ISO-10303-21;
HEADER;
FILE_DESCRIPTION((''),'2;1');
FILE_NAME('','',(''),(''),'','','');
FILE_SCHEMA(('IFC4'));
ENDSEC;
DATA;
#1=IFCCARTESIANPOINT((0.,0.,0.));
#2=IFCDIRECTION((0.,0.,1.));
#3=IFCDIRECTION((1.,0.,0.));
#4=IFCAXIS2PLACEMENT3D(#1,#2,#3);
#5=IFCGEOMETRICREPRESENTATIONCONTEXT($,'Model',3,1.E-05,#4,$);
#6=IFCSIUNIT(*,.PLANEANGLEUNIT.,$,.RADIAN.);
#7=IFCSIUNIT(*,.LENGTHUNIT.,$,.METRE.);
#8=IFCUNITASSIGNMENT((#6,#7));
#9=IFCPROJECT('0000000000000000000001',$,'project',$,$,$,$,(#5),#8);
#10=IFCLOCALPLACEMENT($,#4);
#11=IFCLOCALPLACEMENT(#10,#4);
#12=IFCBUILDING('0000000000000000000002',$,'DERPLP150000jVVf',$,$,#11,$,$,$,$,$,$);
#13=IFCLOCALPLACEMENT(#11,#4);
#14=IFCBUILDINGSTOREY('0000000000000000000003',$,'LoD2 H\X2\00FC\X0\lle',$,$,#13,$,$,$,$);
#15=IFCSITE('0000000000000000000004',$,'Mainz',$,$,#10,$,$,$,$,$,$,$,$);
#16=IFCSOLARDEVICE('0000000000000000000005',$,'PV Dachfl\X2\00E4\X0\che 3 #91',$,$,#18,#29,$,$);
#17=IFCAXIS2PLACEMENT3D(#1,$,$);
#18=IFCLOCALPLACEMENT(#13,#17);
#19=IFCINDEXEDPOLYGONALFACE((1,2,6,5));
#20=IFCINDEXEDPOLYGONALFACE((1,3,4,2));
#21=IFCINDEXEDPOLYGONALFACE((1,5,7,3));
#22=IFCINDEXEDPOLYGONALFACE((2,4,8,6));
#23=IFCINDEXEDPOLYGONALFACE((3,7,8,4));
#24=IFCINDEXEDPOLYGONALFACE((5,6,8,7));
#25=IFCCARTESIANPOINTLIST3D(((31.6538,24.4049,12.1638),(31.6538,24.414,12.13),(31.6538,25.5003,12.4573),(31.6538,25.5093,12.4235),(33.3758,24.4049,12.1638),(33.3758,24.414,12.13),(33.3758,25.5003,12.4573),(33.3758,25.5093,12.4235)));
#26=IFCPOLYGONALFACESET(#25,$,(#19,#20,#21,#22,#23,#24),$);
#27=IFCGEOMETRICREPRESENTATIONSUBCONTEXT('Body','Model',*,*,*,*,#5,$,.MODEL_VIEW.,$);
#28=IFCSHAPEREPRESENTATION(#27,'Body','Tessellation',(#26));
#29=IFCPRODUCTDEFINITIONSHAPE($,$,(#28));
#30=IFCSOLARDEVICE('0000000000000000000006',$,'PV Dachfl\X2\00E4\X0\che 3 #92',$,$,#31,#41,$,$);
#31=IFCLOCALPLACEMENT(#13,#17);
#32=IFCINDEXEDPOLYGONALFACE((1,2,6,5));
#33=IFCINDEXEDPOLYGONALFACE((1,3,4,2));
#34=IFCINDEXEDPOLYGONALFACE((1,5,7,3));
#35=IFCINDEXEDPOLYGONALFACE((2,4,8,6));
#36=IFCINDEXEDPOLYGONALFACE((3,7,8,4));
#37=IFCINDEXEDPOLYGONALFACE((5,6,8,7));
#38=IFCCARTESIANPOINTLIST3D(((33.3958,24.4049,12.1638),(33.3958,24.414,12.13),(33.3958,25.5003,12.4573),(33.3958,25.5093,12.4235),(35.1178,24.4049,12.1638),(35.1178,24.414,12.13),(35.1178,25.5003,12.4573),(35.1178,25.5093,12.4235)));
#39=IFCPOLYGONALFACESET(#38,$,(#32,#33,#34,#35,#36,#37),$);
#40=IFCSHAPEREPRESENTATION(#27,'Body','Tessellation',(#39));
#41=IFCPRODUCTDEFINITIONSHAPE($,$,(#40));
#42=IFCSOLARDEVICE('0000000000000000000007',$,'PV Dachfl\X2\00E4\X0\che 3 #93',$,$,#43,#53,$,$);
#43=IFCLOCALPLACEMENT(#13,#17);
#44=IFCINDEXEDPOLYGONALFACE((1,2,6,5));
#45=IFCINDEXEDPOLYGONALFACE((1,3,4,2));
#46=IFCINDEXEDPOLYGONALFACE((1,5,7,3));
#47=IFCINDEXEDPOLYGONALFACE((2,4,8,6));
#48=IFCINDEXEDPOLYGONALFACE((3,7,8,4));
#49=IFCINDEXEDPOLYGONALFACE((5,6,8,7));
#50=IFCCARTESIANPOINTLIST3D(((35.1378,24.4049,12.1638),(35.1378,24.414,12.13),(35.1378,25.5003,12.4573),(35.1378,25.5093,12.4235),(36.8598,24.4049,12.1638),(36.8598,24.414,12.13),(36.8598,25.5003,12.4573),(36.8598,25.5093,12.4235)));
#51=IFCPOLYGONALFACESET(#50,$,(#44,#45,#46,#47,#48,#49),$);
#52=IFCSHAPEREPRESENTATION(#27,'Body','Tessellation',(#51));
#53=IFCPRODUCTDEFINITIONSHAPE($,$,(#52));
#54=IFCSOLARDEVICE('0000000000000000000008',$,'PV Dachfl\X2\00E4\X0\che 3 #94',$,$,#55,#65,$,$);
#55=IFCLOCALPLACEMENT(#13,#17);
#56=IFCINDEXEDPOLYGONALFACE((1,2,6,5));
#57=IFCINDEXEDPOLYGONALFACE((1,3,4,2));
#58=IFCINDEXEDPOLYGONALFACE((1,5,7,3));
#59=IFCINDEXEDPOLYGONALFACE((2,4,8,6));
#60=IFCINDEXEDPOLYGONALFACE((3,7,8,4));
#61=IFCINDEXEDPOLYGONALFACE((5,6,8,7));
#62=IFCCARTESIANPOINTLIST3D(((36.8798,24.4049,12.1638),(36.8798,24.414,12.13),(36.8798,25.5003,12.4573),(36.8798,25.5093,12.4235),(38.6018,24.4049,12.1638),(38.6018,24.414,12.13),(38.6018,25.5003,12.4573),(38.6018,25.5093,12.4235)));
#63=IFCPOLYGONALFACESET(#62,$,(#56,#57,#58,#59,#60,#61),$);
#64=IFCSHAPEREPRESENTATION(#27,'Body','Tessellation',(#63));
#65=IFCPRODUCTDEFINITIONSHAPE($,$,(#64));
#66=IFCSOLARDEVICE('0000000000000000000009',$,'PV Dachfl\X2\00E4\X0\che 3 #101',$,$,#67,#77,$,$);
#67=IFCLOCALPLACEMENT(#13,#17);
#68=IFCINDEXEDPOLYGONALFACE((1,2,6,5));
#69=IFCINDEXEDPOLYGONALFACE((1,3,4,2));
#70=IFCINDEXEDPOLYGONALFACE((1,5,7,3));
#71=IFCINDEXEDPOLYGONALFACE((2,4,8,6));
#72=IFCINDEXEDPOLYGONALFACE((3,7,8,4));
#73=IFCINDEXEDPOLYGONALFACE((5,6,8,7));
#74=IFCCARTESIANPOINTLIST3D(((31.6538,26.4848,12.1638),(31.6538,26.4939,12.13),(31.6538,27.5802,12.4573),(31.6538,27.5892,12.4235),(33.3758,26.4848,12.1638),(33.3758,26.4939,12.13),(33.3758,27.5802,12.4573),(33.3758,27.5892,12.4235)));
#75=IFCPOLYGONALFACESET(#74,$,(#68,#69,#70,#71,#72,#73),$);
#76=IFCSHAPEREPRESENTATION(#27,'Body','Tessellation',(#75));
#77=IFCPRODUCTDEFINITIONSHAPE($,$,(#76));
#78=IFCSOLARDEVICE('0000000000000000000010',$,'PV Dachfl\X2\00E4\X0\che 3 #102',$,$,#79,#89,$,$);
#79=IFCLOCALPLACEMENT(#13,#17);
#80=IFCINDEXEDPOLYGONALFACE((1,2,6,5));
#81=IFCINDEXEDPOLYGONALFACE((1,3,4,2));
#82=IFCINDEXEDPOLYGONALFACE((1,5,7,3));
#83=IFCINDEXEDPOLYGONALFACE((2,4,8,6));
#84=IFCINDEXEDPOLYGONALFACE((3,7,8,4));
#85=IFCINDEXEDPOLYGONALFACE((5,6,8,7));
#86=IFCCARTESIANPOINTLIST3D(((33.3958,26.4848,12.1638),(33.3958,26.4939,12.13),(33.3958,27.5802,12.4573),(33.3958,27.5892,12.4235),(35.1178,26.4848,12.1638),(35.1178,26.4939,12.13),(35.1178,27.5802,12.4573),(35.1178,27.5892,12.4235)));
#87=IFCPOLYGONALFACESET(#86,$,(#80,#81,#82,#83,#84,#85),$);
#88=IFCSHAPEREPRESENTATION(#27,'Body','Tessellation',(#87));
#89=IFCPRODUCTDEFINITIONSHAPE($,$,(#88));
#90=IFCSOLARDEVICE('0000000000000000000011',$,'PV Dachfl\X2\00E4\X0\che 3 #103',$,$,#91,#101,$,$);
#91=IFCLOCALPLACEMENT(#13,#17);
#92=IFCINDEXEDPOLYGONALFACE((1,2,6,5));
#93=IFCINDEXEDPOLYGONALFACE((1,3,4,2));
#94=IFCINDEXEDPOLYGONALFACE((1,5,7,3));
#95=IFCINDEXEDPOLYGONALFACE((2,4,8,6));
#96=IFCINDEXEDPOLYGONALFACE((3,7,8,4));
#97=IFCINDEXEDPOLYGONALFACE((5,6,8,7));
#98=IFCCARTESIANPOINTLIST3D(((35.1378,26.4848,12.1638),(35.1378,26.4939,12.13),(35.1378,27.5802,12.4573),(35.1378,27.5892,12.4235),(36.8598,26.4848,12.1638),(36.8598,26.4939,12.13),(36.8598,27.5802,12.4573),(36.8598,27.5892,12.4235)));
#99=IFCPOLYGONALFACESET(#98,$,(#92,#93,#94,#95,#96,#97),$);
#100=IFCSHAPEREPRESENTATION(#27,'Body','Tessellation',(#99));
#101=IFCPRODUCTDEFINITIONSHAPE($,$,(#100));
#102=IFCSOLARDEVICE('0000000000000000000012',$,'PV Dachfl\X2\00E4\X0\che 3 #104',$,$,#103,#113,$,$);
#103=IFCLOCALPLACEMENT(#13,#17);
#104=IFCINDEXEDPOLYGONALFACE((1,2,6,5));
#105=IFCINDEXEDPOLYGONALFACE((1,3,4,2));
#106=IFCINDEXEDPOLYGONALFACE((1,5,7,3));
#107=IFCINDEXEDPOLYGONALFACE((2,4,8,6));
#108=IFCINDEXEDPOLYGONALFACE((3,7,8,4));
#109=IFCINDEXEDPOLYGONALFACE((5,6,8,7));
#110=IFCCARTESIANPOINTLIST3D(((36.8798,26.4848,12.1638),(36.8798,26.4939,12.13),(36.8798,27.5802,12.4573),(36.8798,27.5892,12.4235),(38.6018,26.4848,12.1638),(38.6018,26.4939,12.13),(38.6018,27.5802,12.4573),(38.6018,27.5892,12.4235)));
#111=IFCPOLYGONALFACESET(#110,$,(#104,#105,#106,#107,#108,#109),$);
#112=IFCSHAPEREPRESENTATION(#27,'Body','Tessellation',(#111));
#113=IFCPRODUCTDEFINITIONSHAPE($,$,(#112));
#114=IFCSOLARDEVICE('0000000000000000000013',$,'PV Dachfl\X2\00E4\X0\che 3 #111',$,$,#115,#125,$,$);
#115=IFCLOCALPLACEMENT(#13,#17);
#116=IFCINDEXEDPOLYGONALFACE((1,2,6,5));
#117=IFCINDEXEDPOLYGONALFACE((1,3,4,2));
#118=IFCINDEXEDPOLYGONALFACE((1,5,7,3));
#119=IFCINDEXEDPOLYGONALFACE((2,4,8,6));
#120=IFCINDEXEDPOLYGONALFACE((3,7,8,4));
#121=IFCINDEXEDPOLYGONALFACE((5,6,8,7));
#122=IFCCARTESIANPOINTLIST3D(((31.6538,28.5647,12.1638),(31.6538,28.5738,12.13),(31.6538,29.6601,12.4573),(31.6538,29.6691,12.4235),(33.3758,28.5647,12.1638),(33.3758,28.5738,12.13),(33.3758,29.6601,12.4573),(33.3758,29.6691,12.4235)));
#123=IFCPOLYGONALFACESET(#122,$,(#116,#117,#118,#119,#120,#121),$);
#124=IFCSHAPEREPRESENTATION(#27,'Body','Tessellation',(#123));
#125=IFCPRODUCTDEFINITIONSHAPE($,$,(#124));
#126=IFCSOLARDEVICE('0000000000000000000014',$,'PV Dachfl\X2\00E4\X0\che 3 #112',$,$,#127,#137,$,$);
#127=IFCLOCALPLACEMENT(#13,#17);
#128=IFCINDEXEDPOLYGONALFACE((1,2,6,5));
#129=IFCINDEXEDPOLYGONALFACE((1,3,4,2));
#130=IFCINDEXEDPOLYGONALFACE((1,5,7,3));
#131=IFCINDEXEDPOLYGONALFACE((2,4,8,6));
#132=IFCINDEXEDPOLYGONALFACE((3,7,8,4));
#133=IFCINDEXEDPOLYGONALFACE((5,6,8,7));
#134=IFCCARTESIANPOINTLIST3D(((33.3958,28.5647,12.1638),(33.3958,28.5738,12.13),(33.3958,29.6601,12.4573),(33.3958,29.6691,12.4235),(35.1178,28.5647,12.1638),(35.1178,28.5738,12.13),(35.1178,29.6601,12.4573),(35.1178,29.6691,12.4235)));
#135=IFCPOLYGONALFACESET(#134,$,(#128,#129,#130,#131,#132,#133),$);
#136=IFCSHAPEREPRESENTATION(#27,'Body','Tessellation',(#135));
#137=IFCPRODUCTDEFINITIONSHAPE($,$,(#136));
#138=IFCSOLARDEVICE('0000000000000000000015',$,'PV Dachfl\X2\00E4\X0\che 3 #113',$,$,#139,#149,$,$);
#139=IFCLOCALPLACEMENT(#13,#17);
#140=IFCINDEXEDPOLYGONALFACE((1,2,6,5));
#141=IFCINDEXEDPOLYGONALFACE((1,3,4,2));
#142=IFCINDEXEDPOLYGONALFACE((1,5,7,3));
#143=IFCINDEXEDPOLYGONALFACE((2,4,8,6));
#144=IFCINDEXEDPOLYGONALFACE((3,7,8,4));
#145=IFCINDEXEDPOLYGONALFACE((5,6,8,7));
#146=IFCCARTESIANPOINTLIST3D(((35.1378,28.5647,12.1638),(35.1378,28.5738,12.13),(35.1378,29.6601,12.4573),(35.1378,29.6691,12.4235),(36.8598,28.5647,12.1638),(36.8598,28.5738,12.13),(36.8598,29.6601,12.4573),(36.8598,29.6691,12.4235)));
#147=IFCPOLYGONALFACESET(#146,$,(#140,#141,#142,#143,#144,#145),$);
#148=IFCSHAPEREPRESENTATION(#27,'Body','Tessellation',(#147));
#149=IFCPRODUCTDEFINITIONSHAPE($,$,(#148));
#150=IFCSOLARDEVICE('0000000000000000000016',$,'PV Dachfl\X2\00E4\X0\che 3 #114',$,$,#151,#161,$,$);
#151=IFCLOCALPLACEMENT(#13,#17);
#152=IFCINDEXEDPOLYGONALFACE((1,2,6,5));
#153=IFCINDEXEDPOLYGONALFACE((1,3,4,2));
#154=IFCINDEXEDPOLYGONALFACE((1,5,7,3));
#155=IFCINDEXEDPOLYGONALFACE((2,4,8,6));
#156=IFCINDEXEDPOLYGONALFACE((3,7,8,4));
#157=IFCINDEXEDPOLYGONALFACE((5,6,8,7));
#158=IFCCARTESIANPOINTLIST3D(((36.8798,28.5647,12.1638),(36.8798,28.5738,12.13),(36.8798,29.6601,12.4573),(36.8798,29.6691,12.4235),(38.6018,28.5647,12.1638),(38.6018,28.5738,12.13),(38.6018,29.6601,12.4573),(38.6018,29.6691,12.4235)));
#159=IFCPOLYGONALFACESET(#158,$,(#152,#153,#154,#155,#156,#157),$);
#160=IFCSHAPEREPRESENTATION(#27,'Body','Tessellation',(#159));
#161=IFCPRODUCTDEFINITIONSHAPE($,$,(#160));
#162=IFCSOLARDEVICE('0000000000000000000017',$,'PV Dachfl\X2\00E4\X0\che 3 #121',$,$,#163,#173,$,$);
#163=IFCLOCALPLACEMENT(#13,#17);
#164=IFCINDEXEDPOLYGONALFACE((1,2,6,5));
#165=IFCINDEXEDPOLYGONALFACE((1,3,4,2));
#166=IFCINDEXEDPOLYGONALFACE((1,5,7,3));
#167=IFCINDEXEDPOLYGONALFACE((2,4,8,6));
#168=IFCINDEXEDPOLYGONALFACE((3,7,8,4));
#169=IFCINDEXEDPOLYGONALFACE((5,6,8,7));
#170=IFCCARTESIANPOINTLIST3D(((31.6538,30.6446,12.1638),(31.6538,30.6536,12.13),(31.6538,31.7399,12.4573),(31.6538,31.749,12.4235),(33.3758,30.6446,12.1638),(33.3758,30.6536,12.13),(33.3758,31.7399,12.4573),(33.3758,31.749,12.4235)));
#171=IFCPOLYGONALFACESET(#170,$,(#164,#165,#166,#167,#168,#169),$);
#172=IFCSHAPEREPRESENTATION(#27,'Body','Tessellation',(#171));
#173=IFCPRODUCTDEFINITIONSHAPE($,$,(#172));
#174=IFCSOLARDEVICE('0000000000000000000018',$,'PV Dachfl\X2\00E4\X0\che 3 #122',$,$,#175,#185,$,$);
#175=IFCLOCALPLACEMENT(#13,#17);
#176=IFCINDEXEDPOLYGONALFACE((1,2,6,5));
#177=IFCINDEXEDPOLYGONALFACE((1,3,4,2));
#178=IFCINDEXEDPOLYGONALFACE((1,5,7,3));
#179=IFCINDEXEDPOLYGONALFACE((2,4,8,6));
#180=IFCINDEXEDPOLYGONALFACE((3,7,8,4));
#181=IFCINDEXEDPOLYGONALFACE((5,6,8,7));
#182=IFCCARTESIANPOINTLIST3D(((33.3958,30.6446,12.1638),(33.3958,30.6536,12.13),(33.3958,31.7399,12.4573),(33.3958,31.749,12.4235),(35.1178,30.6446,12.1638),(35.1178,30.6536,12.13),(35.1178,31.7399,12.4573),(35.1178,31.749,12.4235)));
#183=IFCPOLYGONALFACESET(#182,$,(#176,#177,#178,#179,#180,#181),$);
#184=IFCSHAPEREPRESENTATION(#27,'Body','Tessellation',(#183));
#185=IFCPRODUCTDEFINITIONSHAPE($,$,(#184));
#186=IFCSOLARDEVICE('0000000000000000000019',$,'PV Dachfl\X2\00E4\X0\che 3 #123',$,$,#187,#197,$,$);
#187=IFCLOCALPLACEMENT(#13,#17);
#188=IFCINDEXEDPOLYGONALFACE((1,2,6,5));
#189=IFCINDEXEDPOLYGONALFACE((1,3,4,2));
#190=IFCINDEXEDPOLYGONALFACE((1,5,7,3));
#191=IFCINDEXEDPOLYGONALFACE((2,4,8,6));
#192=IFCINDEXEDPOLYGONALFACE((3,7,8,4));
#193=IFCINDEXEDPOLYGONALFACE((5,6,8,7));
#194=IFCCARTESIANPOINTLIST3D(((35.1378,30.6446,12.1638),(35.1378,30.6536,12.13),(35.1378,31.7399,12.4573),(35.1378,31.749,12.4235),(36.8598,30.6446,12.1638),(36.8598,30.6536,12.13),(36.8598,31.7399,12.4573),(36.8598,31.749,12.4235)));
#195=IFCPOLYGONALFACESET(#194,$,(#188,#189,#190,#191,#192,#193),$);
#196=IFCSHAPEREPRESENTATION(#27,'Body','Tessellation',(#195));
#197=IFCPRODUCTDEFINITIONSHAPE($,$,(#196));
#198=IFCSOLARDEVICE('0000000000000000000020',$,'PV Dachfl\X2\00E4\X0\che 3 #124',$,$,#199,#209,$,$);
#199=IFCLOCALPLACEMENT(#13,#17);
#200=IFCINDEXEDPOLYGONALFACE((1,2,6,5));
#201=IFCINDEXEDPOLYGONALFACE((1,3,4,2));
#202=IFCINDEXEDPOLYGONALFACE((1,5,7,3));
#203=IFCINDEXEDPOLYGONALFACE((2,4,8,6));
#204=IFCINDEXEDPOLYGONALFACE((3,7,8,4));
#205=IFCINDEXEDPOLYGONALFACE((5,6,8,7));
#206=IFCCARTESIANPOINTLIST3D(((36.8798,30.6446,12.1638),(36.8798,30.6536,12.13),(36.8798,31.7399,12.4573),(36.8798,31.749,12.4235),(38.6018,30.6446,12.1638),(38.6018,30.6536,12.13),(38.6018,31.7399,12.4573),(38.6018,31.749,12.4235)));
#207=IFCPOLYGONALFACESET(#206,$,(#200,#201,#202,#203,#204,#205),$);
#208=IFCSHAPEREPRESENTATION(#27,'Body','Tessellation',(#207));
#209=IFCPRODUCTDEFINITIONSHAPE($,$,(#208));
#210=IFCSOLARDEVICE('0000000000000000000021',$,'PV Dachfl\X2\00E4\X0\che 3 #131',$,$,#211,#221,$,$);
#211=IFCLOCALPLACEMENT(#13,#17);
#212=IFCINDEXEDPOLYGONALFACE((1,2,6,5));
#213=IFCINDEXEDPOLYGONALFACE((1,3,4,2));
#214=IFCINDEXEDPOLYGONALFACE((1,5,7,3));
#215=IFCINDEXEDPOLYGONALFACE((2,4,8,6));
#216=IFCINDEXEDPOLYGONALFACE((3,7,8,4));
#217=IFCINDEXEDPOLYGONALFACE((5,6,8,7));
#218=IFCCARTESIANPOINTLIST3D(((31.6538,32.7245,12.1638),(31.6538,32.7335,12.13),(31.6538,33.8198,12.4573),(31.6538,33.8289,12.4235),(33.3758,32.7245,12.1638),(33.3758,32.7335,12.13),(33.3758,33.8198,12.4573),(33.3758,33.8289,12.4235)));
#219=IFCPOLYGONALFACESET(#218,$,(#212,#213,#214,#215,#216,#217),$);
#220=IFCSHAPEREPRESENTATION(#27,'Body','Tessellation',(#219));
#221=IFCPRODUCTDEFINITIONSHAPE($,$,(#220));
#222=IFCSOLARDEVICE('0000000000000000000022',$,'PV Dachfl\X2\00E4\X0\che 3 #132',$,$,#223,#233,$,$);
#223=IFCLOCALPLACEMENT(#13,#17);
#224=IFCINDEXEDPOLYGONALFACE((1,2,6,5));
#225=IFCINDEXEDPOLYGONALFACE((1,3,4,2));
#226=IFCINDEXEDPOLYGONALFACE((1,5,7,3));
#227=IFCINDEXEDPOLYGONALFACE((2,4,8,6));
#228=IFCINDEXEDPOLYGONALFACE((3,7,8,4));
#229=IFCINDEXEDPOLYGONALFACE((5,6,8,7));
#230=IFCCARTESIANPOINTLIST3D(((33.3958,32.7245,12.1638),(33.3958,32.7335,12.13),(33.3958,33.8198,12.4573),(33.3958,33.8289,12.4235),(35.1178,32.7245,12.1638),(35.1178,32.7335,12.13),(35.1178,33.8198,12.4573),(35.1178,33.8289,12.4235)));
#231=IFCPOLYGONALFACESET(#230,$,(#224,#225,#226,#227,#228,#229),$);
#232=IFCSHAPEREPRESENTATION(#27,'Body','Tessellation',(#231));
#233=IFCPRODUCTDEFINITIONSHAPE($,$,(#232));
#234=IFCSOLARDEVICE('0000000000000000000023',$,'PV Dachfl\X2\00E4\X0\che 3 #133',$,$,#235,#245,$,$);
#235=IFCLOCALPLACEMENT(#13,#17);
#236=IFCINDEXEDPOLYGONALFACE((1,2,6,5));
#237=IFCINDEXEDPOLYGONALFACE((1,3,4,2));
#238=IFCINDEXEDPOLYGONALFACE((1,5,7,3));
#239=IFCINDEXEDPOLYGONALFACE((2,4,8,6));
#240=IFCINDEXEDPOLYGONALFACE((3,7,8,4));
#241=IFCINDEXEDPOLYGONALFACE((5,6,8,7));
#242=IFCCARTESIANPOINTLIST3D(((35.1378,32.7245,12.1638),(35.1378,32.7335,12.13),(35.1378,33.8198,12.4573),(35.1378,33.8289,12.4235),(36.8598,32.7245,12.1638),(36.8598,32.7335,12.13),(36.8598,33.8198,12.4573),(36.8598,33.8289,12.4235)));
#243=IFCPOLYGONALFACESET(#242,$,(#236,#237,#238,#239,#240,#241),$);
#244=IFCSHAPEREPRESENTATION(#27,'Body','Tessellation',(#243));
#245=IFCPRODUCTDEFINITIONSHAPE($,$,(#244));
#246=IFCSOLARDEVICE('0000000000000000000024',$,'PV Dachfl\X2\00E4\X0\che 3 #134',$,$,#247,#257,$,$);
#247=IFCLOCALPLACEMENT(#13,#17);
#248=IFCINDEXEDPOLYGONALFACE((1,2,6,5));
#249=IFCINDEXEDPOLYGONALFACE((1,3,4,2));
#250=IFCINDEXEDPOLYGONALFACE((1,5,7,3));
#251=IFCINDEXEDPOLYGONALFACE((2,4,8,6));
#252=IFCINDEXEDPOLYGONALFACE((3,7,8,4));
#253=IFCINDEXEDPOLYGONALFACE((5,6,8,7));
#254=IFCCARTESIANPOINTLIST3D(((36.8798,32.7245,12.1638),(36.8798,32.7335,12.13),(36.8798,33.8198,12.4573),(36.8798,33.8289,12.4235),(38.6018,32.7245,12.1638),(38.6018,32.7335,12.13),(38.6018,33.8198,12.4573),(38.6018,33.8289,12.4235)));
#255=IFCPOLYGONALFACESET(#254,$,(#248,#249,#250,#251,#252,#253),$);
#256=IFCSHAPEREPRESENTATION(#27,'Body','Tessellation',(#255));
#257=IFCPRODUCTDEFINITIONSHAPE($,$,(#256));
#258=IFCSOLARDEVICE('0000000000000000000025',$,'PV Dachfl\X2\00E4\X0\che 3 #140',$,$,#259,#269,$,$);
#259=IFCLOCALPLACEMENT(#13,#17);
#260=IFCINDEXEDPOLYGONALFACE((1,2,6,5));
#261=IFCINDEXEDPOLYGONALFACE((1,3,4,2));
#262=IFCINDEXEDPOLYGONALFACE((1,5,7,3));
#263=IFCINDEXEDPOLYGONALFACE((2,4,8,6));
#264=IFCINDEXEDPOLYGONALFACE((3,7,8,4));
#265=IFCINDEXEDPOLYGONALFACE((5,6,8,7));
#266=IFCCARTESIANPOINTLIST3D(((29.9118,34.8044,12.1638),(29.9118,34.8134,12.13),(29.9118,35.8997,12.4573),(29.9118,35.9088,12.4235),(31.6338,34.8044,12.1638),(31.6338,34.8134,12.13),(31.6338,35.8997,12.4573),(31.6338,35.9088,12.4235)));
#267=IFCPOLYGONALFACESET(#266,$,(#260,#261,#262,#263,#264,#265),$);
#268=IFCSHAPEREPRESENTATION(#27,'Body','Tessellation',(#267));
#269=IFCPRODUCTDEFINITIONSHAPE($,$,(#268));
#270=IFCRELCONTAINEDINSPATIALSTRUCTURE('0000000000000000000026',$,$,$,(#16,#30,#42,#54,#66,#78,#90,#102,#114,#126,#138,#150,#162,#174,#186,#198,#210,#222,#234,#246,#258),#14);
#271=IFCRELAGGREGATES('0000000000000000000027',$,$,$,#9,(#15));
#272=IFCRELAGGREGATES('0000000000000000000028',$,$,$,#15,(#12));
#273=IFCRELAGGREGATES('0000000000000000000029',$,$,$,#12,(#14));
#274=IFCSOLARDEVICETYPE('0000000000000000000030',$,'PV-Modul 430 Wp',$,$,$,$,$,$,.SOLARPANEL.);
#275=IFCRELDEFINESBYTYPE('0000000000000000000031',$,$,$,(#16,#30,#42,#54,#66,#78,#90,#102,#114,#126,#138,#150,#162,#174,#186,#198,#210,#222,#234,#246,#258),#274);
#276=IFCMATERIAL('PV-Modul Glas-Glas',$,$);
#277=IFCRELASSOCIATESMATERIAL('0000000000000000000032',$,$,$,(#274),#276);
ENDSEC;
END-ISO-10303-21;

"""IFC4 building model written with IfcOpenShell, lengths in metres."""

from ifc_helpers import new_model, si_unit, frame, frame_2d, origin, origin_with_axes, place, context, subcontext, project, spatial, rectangle, extrude, source, transform, mapped, material, type_object, type_shapes, element, save


model = new_model("IFC4")

# Units and contexts
model_context = context("Model", 3, precision=1e-05, world=origin_with_axes())
body_context = subcontext(model_context, "Body", "Model", "MODEL_VIEW")
ifc_project = project(units=[si_unit("PLANEANGLEUNIT", "RADIAN"), si_unit("LENGTHUNIT", "METRE")], contexts=[model_context])

# Site, building, storey
site_placement = place(None, origin_with_axes())
site = spatial("IfcSite", under=ifc_project, at=site_placement, Name="Mainz")
building_placement = place(site_placement, origin_with_axes())
building = spatial("IfcBuilding", under=site, at=building_placement, Name="DERPLP150000jVVf")
storey_placement = place(building_placement, origin_with_axes())
storey = spatial("IfcBuildingStorey", under=building, at=storey_placement, Name="LoD2 Hülle")

# Solar devices
ifc_material = material(Name="PV-Modul Glas-Glas")
solar_device_type = type_object("IfcSolarDeviceType", Name="PV-Modul 430 Wp", PredefinedType="SOLARPANEL", material=ifc_material)
shared_shape = source(origin_with_axes(), body_context, "Body", "SweptSolid", [
    extrude(rectangle(XDim=1.722, YDim=1.134, at=frame_2d((0.861, 0.567))), origin(), (0.0, 0.0, 1.0), 0.035),
])
type_shapes(solar_device_type, [shared_shape])
for number, where, z_axis, x_axis, name in (
    (1, (31.6538, 24.414, 12.13), (0.0, -0.258819, 0.965926), (1.0, 0.0, 0.0), "PV Dachfläche 3 #91"),
    (2, (33.3958, 24.414, 12.13), (0.0, -0.258819, 0.965926), (1.0, 0.0, 0.0), "PV Dachfläche 3 #92"),
    (3, (35.1378, 24.414, 12.13), (0.0, -0.258819, 0.965926), (1.0, 0.0, 0.0), "PV Dachfläche 3 #93"),
    (4, (36.8798, 24.414, 12.13), (0.0, -0.258819, 0.965926), (1.0, 0.0, 0.0), "PV Dachfläche 3 #94"),
    (5, (31.6538, 26.4939, 12.13), (0.0, -0.258819, 0.965926), (1.0, 0.0, 0.0), "PV Dachfläche 3 #101"),
    (6, (33.3958, 26.4939, 12.13), (0.0, -0.258819, 0.965926), (1.0, 0.0, 0.0), "PV Dachfläche 3 #102"),
    (7, (35.1378, 26.4939, 12.13), (0.0, -0.258819, 0.965926), (1.0, 0.0, 0.0), "PV Dachfläche 3 #103"),
    (8, (36.8798, 26.4939, 12.13), (0.0, -0.258819, 0.965926), (1.0, 0.0, 0.0), "PV Dachfläche 3 #104"),
    (9, (31.6538, 28.5738, 12.13), (0.0, -0.258819, 0.965926), (1.0, 0.0, 0.0), "PV Dachfläche 3 #111"),
    (10, (33.3958, 28.5738, 12.13), (0.0, -0.258819, 0.965926), (1.0, 0.0, 0.0), "PV Dachfläche 3 #112"),
    (11, (35.1378, 28.5738, 12.13), (0.0, -0.258819, 0.965926), (1.0, 0.0, 0.0), "PV Dachfläche 3 #113"),
    (12, (36.8798, 28.5738, 12.13), (0.0, -0.258819, 0.965926), (1.0, 0.0, 0.0), "PV Dachfläche 3 #114"),
    (13, (31.6538, 30.6536, 12.13), (0.0, -0.258819, 0.965926), (1.0, 0.0, 0.0), "PV Dachfläche 3 #121"),
    (14, (33.3958, 30.6536, 12.13), (0.0, -0.258819, 0.965926), (1.0, 0.0, 0.0), "PV Dachfläche 3 #122"),
    (15, (35.1378, 30.6536, 12.13), (0.0, -0.258819, 0.965926), (1.0, 0.0, 0.0), "PV Dachfläche 3 #123"),
    (16, (36.8798, 30.6536, 12.13), (0.0, -0.258819, 0.965926), (1.0, 0.0, 0.0), "PV Dachfläche 3 #124"),
    (17, (31.6538, 32.7335, 12.13), (0.0, -0.258819, 0.965926), (1.0, 0.0, 0.0), "PV Dachfläche 3 #131"),
    (18, (33.3958, 32.7335, 12.13), (0.0, -0.258819, 0.965926), (1.0, 0.0, 0.0), "PV Dachfläche 3 #132"),
    (19, (35.1378, 32.7335, 12.13), (0.0, -0.258819, 0.965926), (1.0, 0.0, 0.0), "PV Dachfläche 3 #133"),
    (20, (36.8798, 32.7335, 12.13), (0.0, -0.258819, 0.965926), (1.0, 0.0, 0.0), "PV Dachfläche 3 #134"),
    (21, (29.9118, 34.8134, 12.13), (0.0, -0.258819, 0.965926), (1.0, 0.0, 0.0), "PV Dachfläche 3 #140"),
):
    element("IfcSolarDevice", number, at=place(storey_placement, frame(where, z_axis=z_axis, x_axis=x_axis)), inside=storey, type_object=solar_device_type, Name=name, context=body_context, shape_type="MappedRepresentation", body=[
        mapped(shared_shape, transform((0.0, 0.0, 0.0), x_axis=(1.0, 0.0, 0.0), y_axis=(0.0, 1.0, 0.0), z_axis=(0.0, 0.0, 1.0), scale=1.0)),
    ])

save(model, "model.ifc")
